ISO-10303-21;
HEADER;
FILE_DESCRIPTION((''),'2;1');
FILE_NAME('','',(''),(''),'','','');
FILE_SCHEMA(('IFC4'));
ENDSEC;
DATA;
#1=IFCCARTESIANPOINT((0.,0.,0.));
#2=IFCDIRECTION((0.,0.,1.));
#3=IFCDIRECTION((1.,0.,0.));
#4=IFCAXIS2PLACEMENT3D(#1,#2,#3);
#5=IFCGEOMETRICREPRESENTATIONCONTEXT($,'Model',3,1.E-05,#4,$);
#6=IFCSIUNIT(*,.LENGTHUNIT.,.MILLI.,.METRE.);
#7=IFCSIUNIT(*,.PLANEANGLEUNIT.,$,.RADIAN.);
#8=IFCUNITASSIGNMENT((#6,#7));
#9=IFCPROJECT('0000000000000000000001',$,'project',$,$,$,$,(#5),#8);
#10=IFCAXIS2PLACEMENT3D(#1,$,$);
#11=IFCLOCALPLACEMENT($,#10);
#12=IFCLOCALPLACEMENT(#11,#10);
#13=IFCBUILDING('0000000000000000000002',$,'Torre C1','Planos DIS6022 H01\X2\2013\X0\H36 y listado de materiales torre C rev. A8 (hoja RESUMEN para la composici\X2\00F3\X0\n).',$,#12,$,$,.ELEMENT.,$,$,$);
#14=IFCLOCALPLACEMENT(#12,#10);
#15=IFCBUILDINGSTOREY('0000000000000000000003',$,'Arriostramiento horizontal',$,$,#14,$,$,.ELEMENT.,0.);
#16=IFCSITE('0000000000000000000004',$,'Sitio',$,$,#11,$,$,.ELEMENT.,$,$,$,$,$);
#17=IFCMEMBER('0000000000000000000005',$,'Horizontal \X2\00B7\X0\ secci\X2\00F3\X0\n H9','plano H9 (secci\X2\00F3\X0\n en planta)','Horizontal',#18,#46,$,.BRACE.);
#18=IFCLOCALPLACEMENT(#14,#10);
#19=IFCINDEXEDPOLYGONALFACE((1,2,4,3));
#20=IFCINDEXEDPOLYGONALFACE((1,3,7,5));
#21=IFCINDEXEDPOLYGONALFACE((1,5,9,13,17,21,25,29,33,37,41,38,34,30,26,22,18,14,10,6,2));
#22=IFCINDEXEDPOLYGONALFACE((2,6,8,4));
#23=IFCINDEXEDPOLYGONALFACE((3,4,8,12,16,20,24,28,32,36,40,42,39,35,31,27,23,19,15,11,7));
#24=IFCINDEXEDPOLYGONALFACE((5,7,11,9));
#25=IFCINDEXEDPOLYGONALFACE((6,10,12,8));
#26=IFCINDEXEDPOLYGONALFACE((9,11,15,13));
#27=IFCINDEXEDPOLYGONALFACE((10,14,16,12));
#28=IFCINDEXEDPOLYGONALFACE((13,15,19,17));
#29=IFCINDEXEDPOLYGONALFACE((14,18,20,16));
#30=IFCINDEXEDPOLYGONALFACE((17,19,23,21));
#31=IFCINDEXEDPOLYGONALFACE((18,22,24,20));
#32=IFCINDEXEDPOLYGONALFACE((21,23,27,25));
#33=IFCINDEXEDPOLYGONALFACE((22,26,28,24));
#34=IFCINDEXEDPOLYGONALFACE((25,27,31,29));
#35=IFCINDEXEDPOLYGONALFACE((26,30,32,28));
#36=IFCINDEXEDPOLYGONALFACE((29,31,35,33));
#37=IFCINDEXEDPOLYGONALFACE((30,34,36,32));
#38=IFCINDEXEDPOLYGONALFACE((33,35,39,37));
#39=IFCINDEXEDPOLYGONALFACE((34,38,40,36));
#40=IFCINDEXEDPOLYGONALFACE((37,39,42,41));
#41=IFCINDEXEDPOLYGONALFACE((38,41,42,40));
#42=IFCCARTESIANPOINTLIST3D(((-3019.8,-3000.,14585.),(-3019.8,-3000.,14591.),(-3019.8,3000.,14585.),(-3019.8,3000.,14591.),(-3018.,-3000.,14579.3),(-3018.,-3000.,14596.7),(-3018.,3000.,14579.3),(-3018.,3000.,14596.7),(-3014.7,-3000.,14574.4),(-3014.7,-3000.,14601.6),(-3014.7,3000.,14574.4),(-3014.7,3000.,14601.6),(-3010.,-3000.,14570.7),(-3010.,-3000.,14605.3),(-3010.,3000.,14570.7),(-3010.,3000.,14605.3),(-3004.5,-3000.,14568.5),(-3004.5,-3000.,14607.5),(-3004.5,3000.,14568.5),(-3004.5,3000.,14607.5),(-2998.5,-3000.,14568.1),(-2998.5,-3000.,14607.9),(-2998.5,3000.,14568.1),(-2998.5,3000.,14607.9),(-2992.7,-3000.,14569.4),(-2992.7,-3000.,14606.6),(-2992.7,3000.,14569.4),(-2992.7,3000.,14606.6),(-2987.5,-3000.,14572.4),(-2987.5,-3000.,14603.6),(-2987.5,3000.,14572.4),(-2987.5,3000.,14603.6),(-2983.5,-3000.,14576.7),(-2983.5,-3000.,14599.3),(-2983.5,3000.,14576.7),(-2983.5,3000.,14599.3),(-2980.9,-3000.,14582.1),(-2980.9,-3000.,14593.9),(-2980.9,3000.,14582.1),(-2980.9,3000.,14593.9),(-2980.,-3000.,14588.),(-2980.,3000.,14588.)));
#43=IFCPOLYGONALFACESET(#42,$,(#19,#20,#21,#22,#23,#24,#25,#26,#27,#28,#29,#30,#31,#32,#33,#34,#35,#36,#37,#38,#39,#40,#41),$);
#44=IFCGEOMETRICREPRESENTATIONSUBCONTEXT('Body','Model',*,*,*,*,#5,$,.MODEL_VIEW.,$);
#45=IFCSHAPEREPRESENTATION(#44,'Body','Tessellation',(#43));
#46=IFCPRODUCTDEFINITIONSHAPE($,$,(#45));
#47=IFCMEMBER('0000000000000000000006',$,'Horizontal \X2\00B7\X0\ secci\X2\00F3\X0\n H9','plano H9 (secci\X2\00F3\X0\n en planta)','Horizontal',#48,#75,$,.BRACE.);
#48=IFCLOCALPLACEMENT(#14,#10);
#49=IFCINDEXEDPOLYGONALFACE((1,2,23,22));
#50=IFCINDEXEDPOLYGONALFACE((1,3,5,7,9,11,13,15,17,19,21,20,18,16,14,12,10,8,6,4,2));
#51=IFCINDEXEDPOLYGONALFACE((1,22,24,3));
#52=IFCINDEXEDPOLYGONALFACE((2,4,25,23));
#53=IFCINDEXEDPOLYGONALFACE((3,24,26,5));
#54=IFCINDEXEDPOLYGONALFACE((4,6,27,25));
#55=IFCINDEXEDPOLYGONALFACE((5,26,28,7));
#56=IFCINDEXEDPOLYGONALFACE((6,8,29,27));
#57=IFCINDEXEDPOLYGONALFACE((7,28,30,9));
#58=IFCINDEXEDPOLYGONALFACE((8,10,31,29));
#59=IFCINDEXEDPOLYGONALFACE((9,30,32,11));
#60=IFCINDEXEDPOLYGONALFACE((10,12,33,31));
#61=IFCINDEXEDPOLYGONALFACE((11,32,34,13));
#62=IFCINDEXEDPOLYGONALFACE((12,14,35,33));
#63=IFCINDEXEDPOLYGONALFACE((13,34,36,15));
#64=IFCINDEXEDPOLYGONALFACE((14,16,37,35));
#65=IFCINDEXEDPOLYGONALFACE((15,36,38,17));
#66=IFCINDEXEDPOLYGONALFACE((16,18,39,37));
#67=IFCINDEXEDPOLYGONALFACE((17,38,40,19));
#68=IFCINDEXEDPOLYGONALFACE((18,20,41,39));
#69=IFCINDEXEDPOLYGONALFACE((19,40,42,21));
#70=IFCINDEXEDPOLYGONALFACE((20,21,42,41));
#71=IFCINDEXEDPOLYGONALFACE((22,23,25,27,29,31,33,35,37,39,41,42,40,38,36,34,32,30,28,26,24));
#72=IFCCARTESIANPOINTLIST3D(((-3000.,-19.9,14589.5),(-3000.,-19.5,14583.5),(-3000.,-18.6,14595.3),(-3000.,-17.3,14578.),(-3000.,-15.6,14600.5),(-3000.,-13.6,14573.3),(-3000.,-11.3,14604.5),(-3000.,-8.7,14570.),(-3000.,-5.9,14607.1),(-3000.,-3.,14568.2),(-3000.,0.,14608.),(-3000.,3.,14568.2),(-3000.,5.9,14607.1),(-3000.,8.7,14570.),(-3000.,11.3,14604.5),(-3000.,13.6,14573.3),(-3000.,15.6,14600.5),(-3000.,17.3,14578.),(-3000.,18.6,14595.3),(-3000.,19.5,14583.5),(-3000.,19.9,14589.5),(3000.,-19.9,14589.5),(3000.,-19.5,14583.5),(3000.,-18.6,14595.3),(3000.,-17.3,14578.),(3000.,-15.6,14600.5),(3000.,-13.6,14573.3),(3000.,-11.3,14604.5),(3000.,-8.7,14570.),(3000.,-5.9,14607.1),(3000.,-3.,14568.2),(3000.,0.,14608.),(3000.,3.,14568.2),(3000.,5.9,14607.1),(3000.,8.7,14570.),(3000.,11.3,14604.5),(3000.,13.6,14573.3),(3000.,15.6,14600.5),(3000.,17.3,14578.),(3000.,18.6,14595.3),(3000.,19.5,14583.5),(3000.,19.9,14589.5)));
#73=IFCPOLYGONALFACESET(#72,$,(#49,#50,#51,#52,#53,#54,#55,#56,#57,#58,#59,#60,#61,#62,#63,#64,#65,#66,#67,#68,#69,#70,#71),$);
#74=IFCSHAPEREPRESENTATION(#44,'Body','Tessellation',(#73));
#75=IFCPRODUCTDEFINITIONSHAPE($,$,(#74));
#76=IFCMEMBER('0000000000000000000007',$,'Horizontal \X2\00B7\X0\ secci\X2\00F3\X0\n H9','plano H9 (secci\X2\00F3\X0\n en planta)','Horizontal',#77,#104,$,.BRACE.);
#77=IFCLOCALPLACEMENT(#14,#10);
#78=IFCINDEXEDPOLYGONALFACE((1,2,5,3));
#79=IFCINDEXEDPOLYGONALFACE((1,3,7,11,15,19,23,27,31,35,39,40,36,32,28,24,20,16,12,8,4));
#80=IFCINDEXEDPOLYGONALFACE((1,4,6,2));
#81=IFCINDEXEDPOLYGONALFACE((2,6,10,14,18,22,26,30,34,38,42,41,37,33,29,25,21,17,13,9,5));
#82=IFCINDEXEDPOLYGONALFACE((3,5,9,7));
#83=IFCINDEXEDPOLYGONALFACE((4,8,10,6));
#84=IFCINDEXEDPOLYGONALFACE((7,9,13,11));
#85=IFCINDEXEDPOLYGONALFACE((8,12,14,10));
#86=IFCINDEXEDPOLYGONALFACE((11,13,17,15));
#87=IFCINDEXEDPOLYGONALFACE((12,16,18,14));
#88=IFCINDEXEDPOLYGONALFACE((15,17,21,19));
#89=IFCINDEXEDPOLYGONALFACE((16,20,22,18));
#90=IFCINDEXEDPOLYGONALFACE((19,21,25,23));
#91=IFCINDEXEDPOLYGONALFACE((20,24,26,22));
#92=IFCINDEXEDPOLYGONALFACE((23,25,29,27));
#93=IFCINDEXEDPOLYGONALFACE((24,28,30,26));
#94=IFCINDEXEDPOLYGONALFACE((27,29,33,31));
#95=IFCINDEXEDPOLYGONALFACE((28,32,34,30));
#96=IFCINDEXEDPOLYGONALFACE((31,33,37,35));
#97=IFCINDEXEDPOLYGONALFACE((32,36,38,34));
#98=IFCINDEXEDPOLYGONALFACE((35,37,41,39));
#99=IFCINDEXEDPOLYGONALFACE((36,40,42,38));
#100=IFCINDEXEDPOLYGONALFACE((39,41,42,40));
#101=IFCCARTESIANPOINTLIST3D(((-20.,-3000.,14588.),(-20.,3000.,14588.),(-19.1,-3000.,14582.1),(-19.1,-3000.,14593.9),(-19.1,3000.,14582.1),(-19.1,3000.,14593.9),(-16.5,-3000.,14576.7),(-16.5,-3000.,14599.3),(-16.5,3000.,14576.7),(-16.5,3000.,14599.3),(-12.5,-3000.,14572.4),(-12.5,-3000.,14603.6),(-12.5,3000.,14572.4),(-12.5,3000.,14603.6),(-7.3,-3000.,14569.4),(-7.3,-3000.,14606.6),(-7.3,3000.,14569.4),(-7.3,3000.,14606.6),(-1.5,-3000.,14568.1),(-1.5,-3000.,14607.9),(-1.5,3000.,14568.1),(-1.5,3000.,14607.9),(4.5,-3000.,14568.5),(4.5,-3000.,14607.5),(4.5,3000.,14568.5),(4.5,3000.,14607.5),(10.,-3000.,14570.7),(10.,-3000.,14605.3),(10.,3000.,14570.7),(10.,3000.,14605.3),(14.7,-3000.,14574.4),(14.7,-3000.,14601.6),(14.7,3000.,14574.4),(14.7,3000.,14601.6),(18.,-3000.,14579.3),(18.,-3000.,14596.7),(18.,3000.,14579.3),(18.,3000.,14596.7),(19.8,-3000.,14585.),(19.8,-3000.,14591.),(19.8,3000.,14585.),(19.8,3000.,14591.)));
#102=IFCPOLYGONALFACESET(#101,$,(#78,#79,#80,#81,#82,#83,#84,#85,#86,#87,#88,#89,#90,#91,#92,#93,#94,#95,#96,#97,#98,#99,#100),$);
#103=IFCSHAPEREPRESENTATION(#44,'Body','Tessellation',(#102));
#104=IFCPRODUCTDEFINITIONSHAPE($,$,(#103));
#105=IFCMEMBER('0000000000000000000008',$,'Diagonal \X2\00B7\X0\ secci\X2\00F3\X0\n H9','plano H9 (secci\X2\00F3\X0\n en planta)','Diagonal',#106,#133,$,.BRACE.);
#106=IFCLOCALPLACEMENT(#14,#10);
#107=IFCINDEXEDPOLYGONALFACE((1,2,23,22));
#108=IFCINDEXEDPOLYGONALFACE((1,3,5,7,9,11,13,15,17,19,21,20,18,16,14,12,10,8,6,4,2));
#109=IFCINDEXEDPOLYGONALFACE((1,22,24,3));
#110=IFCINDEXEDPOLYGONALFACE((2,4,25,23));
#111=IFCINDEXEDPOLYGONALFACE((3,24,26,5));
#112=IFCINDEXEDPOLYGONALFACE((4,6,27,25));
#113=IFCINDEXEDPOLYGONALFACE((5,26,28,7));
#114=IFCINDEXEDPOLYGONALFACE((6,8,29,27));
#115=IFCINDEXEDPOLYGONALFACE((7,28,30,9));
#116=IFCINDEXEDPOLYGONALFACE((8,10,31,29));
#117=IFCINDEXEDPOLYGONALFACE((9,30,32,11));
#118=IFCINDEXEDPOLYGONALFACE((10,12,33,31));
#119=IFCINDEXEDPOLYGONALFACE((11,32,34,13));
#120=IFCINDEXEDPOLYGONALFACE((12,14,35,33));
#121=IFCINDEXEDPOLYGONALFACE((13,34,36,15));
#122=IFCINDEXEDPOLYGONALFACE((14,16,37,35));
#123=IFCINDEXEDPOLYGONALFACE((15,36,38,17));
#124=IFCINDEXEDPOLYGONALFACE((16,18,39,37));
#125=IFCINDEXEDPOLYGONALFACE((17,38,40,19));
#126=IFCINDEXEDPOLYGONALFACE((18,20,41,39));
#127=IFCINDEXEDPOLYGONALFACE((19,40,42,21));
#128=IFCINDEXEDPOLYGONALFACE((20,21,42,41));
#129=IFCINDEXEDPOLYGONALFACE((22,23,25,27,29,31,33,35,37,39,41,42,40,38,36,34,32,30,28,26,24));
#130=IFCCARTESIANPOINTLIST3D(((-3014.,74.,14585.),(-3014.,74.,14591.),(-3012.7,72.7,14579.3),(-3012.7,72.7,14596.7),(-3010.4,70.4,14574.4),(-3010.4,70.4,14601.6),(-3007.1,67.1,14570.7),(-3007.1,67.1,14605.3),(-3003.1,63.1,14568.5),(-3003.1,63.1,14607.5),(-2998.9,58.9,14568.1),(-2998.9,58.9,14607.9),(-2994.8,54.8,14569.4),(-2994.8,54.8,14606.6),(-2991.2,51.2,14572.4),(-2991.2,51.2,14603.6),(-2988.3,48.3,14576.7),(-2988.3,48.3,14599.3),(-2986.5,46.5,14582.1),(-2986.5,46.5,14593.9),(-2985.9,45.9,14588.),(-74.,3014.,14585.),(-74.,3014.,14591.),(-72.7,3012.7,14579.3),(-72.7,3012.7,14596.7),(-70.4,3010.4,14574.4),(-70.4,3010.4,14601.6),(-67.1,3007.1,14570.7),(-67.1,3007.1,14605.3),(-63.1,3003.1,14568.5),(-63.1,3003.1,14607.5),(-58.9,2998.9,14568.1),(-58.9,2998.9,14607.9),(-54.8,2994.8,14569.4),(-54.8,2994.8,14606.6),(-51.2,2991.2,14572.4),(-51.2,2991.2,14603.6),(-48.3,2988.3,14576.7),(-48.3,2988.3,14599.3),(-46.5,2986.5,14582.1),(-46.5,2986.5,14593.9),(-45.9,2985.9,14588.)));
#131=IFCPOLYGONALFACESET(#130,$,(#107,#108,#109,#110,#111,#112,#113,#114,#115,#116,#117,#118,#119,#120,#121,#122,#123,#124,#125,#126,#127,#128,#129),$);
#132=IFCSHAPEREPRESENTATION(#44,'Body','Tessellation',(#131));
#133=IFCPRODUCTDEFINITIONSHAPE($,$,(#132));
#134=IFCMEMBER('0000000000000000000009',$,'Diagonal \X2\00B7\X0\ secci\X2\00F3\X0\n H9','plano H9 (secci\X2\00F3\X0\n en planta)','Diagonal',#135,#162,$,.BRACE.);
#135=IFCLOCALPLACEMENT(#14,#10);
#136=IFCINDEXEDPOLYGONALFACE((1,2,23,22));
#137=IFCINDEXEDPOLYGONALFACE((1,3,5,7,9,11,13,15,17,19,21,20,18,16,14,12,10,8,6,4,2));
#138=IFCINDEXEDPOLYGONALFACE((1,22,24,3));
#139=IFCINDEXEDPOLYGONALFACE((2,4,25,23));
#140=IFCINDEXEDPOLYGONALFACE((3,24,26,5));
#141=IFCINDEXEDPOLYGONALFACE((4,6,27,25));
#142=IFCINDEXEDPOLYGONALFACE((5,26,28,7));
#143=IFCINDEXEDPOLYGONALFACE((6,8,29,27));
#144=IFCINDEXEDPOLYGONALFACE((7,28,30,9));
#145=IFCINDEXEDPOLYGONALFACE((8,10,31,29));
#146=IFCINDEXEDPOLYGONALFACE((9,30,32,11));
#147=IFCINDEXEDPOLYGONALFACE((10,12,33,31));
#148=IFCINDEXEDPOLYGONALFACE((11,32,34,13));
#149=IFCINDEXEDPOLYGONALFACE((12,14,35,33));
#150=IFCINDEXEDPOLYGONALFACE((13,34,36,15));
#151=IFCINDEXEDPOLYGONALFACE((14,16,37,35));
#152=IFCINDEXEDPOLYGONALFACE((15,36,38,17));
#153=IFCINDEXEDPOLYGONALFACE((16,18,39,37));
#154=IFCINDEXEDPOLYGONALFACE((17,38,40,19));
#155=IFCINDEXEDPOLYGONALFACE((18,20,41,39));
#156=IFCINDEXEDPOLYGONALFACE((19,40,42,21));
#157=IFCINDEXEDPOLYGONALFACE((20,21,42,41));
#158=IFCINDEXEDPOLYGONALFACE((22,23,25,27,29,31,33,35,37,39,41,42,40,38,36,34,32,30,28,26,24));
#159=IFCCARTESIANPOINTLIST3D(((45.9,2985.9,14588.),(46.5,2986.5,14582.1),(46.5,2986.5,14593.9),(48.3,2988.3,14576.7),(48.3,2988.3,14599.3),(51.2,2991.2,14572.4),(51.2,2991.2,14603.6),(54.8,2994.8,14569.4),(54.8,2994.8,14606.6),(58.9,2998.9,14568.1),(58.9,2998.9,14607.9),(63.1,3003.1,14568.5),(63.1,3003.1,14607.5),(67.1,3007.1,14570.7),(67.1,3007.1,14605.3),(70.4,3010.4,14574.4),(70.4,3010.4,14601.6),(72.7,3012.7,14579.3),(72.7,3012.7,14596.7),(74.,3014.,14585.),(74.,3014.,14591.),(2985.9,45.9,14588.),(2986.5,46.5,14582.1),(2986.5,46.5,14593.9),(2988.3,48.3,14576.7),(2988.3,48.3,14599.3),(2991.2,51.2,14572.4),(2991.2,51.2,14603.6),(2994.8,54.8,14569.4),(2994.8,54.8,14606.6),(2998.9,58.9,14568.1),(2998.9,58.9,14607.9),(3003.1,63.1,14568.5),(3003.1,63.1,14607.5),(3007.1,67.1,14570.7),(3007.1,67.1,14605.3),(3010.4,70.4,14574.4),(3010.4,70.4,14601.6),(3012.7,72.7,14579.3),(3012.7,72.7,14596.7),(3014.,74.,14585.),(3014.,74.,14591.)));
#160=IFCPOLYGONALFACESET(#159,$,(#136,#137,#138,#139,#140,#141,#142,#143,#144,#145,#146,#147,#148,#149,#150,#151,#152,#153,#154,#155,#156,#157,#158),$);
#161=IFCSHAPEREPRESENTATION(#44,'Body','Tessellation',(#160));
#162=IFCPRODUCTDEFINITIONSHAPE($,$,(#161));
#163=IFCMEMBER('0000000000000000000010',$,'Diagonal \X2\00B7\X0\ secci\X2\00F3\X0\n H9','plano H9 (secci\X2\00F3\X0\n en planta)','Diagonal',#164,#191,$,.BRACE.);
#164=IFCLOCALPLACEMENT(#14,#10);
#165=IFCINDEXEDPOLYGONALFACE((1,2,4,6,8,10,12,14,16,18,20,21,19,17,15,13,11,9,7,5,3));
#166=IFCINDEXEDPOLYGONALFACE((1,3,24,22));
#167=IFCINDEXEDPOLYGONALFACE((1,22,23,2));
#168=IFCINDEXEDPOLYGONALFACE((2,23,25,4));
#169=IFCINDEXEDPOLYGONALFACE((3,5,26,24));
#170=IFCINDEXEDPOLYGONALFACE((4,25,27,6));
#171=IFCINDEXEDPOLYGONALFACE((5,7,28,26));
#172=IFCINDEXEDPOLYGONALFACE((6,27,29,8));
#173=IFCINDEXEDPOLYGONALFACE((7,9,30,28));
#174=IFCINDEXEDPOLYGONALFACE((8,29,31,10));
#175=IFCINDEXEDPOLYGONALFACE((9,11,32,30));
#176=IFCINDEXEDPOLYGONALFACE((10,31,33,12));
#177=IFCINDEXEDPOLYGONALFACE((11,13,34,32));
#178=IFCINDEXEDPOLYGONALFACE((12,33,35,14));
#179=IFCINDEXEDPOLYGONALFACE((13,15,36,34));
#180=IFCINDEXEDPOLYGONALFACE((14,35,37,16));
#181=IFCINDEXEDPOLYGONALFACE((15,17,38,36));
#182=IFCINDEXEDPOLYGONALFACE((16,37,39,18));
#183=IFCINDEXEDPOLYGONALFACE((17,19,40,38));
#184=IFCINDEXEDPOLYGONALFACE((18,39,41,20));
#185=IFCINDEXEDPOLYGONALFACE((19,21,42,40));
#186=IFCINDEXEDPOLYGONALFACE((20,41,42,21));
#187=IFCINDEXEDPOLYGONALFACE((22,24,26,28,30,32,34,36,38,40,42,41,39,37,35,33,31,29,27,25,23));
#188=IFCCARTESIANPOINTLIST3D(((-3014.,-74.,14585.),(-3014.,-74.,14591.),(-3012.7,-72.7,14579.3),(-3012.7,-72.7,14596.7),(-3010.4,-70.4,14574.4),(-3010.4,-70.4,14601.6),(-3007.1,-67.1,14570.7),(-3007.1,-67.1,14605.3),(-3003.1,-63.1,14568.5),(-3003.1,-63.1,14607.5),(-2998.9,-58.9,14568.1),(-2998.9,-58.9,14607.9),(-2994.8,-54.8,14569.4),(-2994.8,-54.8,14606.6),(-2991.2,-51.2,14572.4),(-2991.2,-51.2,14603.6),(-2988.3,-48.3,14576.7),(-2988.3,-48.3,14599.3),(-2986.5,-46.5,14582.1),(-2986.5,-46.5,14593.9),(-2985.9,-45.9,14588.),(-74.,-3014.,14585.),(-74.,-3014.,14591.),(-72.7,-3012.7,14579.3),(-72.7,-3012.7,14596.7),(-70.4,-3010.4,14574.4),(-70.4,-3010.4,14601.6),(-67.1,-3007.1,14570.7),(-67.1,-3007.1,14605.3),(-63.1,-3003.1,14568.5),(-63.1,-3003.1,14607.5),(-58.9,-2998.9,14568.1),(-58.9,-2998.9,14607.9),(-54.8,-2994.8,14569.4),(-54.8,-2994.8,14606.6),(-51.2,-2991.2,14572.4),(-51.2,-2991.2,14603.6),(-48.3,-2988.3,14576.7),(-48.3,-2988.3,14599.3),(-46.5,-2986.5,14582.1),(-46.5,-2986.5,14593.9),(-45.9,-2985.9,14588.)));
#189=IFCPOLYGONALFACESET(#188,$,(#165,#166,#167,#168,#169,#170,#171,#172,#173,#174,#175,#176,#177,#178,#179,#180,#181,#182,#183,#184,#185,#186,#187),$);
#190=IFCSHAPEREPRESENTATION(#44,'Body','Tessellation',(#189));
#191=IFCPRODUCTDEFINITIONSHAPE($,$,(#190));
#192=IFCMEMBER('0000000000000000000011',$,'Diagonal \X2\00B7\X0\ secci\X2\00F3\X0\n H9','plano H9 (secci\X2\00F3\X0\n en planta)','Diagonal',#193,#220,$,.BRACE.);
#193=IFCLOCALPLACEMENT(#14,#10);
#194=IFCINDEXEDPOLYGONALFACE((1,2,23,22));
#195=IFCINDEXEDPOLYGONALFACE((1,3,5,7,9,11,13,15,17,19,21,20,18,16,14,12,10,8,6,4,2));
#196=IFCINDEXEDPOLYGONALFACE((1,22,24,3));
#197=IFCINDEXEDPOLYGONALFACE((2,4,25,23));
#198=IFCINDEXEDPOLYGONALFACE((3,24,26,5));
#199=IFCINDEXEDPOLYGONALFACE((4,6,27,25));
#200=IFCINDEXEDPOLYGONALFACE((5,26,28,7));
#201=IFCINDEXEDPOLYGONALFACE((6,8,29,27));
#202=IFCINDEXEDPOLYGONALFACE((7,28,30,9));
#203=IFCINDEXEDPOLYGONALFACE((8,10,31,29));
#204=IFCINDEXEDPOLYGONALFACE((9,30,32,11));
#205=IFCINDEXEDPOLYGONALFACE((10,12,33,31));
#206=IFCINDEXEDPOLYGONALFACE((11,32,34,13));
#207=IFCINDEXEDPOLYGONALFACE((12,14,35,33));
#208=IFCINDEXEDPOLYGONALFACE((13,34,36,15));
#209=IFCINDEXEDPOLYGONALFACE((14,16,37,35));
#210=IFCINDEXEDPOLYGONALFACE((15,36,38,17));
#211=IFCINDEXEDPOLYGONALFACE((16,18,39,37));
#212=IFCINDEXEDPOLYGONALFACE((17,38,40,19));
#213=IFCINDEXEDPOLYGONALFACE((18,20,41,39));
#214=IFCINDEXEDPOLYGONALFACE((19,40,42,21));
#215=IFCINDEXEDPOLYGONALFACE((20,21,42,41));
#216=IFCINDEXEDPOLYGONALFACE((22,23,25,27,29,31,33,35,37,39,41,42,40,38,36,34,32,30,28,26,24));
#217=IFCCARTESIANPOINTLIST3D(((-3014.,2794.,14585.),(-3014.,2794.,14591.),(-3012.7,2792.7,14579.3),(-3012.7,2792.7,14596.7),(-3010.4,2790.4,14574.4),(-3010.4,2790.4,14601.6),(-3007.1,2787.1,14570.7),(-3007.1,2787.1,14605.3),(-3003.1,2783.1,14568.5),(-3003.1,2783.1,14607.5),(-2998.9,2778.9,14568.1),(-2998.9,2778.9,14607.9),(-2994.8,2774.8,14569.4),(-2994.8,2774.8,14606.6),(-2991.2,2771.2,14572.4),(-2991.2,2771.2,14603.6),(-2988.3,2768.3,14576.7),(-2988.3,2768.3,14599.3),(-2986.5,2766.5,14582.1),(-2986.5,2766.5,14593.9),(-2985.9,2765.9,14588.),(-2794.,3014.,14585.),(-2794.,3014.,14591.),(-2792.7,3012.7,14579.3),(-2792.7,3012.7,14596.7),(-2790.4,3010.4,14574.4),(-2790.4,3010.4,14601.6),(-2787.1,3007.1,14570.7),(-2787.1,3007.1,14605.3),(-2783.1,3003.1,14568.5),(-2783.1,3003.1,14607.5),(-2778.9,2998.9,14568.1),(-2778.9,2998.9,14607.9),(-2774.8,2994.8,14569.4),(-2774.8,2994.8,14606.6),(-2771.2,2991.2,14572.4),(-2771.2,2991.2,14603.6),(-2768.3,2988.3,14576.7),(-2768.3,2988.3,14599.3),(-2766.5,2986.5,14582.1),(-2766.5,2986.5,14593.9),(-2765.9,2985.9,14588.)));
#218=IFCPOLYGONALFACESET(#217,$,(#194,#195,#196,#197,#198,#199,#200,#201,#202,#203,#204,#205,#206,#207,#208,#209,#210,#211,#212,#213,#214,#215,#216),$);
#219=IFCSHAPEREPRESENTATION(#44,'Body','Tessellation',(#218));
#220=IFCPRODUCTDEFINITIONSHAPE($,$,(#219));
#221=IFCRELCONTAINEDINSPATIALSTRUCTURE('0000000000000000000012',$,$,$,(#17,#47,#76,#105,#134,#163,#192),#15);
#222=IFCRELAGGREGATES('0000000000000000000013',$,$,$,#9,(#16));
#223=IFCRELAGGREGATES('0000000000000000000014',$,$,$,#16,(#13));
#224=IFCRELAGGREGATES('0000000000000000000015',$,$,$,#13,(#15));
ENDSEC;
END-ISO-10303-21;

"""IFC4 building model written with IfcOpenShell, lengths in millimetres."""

from ifc_helpers import new_model, si_unit, frame, origin, origin_with_axes, place, context, subcontext, project, spatial, circle, extrude, element, save


model = new_model("IFC4")

# Units and contexts
model_context = context("Model", 3, precision=1e-05, world=origin_with_axes())
body_context = subcontext(model_context, "Body", "Model", "MODEL_VIEW")
ifc_project = project(units=[si_unit("LENGTHUNIT", "METRE", prefix="MILLI"), si_unit("PLANEANGLEUNIT", "RADIAN")], contexts=[model_context])

# Site, building, storey
site_placement = place(None, origin())
site = spatial("IfcSite", under=ifc_project, at=site_placement, Name="Sitio", CompositionType="ELEMENT")
building_placement = place(site_placement, origin())
building = spatial("IfcBuilding", under=site, at=building_placement, Name="Torre C1", Description="Planos DIS6022 H01–H36 y listado de materiales torre C rev. A8 (hoja RESUMEN para la composición).", CompositionType="ELEMENT")
storey_placement = place(building_placement, origin())
storey = spatial("IfcBuildingStorey", under=building, at=storey_placement, Name="Arriostramiento horizontal", CompositionType="ELEMENT", Elevation=0.0)

# Members
for number, where, z_axis, x_axis, name in (
    (1, (-3000.0, 3000.0, 14588.0), (0.0, -1.0, 0.0), (1.0, 0.0, 0.0), "Horizontal · sección H9"),
    (2, (-3000.0, 0.0, 14588.0), (1.0, 0.0, 0.0), (0.0, 0.0, 1.0), "Horizontal · sección H9"),
    (3, (0.0, 3000.0, 14588.0), (0.0, -1.0, 0.0), (-1.0, 0.0, 0.0), "Horizontal · sección H9"),
):
    element("IfcMember", number, at=place(storey_placement, frame(where, z_axis=z_axis, x_axis=x_axis)), inside=storey, Name=name, Description="plano H9 (sección en planta)", ObjectType="Horizontal", PredefinedType="BRACE", context=body_context, shape_type="SweptSolid", body=[
        extrude(circle(Radius=20.0), None, (0.0, 0.0, 1.0), 6000.0),
    ])
for number, where, z_axis, x_axis, name in (
    (4, (-3000.0, 60.0, 14588.0), (0.707107, 0.707107, 0.0), (0.707107, -0.707107, 0.0), "Diagonal · sección H9"),
    (5, (60.0, 3000.0, 14588.0), (0.707107, -0.707107, 0.0), (-0.707107, -0.707107, 0.0), "Diagonal · sección H9"),
    (6, (-60.0, -3000.0, 14588.0), (-0.707107, 0.707107, 0.0), (0.707107, 0.707107, 0.0), "Diagonal · sección H9"),
):
    element("IfcMember", number, at=place(storey_placement, frame(where, z_axis=z_axis, x_axis=x_axis)), inside=storey, Name=name, Description="plano H9 (sección en planta)", ObjectType="Diagonal", PredefinedType="BRACE", context=body_context, shape_type="SweptSolid", body=[
        extrude(circle(Radius=20.0), None, (0.0, 0.0, 1.0), 4157.8),
    ])
member_1_placement = place(storey_placement, frame((-2780.0, 3000.0, 14588.0), z_axis=(-0.707107, -0.707107, 0.0), x_axis=(0.707107, -0.707107, 0.0)))
element("IfcMember", 7, at=member_1_placement, inside=storey, Name="Diagonal · sección H9", Description="plano H9 (sección en planta)", ObjectType="Diagonal", PredefinedType="BRACE", context=body_context, shape_type="SweptSolid", body=[
    extrude(circle(Radius=20.0), None, (0.0, 0.0, 1.0), 311.1),
])

save(model, "model.ifc")
